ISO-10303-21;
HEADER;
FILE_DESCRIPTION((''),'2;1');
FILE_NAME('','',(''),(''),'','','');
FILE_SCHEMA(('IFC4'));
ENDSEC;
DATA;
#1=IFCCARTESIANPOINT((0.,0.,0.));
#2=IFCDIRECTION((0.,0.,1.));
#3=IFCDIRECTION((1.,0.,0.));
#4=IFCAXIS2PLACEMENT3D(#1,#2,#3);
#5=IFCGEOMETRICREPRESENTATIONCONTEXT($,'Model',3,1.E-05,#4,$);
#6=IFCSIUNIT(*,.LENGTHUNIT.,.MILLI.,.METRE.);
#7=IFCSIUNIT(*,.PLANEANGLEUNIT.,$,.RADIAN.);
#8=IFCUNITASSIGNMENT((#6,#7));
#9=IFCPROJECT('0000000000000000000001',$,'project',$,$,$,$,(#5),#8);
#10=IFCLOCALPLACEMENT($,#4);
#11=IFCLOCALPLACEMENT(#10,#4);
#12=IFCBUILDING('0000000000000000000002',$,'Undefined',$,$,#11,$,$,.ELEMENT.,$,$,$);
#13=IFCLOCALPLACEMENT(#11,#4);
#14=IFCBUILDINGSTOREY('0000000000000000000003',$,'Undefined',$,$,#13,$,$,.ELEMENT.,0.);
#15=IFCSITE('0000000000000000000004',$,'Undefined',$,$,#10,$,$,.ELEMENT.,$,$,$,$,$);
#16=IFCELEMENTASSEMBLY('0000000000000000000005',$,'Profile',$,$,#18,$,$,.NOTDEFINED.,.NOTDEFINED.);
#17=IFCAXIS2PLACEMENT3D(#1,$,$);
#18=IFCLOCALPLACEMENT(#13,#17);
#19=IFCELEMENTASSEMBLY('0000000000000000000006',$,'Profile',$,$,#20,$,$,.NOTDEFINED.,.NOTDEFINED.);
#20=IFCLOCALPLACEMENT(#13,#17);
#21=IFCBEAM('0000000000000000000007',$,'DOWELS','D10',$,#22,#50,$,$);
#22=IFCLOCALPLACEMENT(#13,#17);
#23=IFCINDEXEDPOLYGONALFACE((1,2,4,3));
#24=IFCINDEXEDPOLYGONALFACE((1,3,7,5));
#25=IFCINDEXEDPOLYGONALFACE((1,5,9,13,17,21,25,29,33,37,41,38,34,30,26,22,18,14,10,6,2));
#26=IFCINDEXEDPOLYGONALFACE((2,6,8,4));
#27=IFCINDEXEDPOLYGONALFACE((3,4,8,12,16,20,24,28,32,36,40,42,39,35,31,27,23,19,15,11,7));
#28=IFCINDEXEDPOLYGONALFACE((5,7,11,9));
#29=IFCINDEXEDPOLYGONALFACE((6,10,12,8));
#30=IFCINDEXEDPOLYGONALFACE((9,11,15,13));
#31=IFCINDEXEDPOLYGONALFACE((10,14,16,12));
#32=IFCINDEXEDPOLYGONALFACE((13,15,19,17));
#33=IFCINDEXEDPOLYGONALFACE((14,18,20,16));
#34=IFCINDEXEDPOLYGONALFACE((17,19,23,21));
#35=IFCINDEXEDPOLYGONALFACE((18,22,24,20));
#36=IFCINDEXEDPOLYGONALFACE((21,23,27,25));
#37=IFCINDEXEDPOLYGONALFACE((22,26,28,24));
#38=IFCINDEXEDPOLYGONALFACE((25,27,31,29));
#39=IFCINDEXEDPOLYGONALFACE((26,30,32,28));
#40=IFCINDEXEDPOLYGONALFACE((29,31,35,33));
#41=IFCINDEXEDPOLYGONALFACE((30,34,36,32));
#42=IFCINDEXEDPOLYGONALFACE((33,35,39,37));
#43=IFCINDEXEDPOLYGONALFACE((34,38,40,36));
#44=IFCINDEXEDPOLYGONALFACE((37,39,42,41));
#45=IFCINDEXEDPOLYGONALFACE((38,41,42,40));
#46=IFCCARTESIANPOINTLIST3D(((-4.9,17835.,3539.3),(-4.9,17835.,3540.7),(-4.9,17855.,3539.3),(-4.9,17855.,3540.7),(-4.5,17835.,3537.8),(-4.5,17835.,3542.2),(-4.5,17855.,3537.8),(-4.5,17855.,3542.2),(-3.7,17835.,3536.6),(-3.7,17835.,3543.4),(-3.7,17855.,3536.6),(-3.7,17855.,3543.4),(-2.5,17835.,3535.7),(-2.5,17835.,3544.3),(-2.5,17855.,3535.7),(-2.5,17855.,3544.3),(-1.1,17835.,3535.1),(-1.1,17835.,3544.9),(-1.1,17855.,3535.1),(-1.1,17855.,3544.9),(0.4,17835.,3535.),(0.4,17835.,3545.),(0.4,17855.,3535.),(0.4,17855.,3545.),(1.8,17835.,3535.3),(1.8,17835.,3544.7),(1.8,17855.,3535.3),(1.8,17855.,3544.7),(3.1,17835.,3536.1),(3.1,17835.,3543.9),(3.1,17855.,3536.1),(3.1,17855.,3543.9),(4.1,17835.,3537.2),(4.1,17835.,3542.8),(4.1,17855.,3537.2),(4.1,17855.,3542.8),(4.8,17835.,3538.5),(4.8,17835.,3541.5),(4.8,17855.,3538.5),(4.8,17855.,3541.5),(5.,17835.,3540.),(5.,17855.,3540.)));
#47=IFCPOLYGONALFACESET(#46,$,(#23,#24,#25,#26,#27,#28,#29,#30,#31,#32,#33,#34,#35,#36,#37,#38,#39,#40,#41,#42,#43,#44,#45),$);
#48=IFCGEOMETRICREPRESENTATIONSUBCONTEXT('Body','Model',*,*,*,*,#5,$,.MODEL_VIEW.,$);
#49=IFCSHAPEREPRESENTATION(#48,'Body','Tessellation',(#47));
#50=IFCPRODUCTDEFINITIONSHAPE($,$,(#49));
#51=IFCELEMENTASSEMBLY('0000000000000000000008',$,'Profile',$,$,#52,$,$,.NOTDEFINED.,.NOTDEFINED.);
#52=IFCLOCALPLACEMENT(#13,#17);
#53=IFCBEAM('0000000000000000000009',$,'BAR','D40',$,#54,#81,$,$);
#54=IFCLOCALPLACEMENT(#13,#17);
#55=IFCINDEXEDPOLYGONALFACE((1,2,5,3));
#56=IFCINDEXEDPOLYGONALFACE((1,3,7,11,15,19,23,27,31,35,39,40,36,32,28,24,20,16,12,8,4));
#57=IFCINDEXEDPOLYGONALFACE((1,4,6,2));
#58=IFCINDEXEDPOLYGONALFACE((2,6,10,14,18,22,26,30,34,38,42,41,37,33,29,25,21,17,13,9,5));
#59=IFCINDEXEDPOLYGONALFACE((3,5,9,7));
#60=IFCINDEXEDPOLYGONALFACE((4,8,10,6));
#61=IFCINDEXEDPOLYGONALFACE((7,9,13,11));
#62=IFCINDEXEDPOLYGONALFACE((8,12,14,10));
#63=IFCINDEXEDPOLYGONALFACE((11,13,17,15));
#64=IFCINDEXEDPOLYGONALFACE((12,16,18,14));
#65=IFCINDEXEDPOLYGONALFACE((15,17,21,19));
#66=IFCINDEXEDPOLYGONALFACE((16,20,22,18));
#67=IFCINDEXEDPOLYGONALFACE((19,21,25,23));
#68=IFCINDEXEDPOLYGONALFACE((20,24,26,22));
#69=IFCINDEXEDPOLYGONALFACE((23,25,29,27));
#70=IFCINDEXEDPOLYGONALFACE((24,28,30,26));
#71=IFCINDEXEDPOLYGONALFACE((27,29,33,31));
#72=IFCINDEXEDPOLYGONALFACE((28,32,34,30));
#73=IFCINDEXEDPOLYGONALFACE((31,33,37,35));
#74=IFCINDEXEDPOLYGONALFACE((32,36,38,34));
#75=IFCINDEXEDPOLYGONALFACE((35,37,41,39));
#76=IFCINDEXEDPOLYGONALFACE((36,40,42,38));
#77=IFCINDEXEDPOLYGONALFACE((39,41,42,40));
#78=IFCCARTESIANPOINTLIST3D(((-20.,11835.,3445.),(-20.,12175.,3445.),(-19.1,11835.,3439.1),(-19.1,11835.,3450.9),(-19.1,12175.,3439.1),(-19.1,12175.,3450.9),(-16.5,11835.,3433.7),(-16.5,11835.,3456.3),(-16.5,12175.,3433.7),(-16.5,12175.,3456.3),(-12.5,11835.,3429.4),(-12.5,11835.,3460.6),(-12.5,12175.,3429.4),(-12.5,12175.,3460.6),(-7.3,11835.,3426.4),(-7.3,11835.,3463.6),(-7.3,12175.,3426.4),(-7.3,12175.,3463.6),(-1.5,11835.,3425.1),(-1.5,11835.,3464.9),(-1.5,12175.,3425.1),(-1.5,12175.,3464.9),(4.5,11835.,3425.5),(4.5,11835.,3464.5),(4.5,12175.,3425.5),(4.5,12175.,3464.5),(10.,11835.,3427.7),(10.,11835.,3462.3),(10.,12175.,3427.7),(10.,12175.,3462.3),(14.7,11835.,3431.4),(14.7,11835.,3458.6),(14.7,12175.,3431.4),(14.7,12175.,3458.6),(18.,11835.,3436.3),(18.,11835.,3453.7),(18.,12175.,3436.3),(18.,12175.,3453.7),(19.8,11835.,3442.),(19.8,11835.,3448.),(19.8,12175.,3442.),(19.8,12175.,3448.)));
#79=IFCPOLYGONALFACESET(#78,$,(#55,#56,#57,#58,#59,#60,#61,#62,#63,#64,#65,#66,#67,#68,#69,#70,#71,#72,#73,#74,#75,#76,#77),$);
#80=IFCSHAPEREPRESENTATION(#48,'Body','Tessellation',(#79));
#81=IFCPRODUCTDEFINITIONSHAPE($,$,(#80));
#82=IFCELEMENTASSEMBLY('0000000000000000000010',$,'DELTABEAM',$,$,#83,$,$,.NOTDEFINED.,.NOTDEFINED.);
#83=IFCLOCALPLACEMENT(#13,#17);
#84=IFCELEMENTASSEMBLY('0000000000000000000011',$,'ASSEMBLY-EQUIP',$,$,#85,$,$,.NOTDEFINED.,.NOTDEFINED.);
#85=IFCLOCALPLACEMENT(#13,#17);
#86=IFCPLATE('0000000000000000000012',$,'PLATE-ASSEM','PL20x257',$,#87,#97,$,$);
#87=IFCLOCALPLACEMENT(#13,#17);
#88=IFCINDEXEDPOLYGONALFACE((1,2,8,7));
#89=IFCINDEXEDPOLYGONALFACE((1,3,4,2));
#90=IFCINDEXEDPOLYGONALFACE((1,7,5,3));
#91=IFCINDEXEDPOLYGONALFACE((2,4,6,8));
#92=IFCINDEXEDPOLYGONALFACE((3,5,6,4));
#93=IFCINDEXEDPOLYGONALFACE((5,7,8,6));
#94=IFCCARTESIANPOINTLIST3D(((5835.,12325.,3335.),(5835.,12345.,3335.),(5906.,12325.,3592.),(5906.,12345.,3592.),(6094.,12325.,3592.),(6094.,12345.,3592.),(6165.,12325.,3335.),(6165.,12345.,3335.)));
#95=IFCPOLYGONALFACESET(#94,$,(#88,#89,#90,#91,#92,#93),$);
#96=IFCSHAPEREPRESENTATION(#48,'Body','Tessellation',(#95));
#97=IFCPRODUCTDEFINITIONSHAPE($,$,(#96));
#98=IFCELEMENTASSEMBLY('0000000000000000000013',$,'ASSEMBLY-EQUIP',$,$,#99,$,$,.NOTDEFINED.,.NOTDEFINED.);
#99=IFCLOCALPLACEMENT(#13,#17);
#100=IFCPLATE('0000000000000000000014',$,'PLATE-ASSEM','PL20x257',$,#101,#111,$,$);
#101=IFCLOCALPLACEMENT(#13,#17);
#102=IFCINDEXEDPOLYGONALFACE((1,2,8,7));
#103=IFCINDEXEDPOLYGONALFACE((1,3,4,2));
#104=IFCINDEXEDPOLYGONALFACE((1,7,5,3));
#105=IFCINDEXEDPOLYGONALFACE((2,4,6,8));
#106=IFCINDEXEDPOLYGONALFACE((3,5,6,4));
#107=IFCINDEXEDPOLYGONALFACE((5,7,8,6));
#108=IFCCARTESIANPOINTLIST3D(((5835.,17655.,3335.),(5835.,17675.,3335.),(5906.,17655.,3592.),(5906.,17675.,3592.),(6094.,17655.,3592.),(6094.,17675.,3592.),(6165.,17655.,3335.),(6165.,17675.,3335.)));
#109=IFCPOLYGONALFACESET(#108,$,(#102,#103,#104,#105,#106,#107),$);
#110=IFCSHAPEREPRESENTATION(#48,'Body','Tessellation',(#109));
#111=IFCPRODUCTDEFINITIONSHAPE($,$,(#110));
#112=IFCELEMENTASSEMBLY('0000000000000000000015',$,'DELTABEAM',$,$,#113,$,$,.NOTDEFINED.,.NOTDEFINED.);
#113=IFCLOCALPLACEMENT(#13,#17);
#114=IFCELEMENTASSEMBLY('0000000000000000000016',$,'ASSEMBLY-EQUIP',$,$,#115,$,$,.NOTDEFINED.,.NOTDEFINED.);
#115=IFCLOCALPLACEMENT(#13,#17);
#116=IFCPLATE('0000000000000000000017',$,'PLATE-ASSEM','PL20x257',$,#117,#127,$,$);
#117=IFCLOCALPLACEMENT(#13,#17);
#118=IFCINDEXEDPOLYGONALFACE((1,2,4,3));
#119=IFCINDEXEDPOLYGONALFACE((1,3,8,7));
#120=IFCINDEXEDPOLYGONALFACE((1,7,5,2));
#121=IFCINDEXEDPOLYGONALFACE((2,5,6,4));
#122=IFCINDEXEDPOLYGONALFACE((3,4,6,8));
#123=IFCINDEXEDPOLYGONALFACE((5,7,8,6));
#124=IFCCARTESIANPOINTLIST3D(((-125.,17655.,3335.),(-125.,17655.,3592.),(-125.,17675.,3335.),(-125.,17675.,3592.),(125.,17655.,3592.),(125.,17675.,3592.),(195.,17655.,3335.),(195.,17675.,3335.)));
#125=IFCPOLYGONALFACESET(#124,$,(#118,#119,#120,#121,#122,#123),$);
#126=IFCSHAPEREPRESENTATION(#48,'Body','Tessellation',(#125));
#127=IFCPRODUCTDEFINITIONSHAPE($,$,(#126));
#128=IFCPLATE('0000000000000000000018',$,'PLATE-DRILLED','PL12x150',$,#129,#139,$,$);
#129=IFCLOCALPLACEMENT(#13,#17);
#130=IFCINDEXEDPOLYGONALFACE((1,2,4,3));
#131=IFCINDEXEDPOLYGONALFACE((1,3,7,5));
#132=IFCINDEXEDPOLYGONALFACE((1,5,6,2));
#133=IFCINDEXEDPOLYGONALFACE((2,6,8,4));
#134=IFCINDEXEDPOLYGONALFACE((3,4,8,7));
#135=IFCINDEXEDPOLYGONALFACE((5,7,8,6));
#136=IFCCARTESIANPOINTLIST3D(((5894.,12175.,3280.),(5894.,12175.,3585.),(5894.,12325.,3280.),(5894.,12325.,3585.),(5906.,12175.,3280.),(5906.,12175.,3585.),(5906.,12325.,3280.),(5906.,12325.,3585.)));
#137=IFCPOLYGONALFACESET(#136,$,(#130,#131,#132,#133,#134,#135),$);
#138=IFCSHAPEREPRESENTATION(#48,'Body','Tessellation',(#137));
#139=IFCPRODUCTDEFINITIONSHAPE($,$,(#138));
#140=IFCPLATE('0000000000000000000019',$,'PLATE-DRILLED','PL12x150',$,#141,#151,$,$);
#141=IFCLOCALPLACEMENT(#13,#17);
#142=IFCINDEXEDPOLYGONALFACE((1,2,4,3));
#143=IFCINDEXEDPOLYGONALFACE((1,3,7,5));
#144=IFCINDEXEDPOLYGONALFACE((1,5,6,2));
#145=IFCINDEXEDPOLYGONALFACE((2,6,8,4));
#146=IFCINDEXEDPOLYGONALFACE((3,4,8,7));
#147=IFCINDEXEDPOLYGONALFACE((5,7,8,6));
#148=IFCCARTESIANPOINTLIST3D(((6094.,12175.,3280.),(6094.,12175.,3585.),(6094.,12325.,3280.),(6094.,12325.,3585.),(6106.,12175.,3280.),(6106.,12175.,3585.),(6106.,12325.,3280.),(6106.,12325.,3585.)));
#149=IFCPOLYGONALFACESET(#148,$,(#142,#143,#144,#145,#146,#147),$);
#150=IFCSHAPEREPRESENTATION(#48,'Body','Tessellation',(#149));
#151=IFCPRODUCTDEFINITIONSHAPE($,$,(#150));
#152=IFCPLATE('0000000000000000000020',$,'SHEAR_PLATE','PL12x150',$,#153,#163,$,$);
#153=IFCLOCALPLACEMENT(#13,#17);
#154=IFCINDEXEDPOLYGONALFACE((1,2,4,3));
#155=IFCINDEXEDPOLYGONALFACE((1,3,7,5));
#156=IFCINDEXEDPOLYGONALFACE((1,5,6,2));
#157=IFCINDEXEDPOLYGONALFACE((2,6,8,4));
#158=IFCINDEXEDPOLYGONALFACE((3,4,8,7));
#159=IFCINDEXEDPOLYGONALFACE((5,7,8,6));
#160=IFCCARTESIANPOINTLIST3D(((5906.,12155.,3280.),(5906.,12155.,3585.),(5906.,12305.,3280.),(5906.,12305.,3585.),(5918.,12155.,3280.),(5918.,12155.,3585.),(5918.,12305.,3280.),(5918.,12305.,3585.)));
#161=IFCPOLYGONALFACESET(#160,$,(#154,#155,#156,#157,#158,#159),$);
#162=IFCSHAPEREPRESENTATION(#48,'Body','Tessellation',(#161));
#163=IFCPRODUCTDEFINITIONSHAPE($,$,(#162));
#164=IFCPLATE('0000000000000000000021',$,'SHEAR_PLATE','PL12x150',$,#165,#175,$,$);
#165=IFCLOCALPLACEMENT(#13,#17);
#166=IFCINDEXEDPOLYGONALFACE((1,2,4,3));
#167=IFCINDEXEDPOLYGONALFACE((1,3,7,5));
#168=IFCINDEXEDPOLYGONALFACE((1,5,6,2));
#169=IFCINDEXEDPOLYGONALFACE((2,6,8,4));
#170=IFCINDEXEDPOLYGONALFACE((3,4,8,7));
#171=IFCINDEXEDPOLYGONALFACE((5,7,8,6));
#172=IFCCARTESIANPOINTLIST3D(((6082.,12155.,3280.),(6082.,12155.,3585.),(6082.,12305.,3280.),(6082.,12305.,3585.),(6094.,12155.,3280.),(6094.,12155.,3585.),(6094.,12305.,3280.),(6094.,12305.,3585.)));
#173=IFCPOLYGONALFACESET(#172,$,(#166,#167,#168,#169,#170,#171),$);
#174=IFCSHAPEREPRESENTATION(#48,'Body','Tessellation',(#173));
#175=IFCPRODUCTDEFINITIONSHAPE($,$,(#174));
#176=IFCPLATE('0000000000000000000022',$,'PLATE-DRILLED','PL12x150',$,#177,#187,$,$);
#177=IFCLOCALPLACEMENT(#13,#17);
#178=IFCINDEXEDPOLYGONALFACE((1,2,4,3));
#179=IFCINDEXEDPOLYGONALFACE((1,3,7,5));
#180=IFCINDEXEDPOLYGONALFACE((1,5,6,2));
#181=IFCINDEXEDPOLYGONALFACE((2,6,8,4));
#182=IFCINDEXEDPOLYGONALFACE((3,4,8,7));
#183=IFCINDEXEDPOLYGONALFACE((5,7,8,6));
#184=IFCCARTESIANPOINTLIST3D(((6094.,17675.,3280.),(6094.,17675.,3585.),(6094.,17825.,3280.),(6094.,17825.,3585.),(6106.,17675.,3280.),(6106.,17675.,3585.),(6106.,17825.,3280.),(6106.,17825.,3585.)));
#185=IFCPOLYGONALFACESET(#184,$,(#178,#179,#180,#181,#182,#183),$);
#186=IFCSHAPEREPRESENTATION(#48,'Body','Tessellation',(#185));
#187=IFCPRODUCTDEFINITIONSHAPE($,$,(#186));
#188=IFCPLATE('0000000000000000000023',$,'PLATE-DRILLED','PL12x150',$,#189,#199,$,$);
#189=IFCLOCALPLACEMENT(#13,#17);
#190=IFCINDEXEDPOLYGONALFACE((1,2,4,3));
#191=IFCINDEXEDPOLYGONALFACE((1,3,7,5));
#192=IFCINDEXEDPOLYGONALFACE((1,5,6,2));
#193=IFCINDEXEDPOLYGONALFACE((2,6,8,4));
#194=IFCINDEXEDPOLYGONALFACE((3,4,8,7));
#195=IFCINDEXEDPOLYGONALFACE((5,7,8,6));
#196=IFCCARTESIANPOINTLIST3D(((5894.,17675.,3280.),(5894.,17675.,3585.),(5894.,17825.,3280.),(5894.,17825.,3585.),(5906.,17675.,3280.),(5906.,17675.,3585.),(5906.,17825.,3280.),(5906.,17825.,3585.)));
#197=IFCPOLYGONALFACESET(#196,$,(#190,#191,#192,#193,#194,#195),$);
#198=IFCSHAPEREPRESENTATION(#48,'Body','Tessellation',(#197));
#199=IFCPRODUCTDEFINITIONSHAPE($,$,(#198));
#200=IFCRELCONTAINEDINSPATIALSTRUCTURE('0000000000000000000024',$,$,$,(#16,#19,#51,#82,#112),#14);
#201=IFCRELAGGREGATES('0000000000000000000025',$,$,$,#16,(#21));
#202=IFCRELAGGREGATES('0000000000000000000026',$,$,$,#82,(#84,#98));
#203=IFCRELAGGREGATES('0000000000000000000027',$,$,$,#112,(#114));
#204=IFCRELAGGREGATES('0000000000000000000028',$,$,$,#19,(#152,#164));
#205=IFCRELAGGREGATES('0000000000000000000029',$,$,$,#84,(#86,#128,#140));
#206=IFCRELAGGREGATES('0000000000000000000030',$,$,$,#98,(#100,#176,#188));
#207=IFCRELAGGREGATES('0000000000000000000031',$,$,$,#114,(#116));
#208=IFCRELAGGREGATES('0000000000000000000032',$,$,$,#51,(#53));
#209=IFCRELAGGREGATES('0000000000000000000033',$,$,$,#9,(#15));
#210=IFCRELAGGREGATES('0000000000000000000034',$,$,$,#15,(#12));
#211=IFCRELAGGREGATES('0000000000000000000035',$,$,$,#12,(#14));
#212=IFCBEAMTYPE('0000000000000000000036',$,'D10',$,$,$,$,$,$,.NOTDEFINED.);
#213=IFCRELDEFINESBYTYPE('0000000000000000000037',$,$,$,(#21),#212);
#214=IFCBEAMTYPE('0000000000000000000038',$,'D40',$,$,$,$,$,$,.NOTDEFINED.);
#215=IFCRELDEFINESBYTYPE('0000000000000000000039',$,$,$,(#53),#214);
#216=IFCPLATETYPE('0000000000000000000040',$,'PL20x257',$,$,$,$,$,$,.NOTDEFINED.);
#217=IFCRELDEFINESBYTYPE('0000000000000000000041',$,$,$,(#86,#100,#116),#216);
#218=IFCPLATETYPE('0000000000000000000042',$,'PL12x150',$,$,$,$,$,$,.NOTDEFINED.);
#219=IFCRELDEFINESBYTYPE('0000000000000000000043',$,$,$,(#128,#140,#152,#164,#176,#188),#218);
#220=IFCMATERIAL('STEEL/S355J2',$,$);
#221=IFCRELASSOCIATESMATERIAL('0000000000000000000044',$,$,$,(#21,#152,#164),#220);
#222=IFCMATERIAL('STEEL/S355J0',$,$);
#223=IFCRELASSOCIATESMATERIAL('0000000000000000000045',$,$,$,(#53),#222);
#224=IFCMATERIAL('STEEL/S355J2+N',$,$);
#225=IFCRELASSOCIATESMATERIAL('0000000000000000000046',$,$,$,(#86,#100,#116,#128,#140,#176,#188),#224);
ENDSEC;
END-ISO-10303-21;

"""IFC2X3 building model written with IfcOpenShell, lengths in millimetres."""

from ifc_helpers import new_model, si_unit, frame, origin_with_axes, origin_2d_with_axis, place, context, subcontext, project, spatial, polyline, circle, outline, extrude, material, type_object, element, aggregate, save


model = new_model("IFC2X3")

# Units and contexts
model_context = context("Model", 3, precision=1e-05, world=origin_with_axes())
body_context = subcontext(model_context, "Body", "Model", "MODEL_VIEW")
ifc_project = project(units=[si_unit("LENGTHUNIT", "METRE", prefix="MILLI"), si_unit("PLANEANGLEUNIT", "RADIAN")], contexts=[model_context])

# Site, building, storey
site_placement = place(None, origin_with_axes())
site = spatial("IfcSite", under=ifc_project, at=site_placement, Name="Undefined", CompositionType="ELEMENT")
building_placement = place(site_placement, origin_with_axes())
building = spatial("IfcBuilding", under=site, at=building_placement, Name="Undefined", CompositionType="ELEMENT")
storey_placement = place(building_placement, origin_with_axes())
storey = spatial("IfcBuildingStorey", under=building, at=storey_placement, Name="Undefined", CompositionType="ELEMENT", Elevation=0.0)

# Element assembly
assembly_1_placement = place(storey_placement, origin_with_axes())
assembly_1 = element("IfcElementAssembly", 1, at=assembly_1_placement, inside=storey, Name="Profile", AssemblyPlace="NOTDEFINED", PredefinedType="NOTDEFINED")

# Element assembly
assembly_2_placement = place(storey_placement, origin_with_axes())
assembly_2 = element("IfcElementAssembly", 2, at=assembly_2_placement, inside=storey, Name="Profile", AssemblyPlace="NOTDEFINED", PredefinedType="NOTDEFINED")
ifc_material_1 = material(Name="STEEL/S355J2")
beam_type_1 = type_object("IfcBeamType", Name="D10", PredefinedType="NOTDEFINED")

# Beam
beam_1_placement = place(assembly_1_placement, frame((0.0, 17835.0, 3540.0), z_axis=(0.0, 0.0, 1.0), x_axis=(0.0, 1.0, 0.0)))
beam_1 = element("IfcBeam", 3, at=beam_1_placement, type_object=beam_type_1, material=ifc_material_1, Name="DOWELS", Description="D10", context=body_context, shape_type="SweptSolid", body=[
    extrude(circle(Radius=5.0, at=origin_2d_with_axis()), frame((20.0, 0.0, 0.0), z_axis=(-1.0, 0.0, 0.0), x_axis=(0.0, -1.0, 0.0)), (0.0, 0.0, 1.0), 20.0),
])
aggregate(assembly_1, [beam_1])

# Element assembly, beam
assembly_3_placement = place(storey_placement, origin_with_axes())
assembly_3 = element("IfcElementAssembly", 4, at=assembly_3_placement, inside=storey, Name="Profile", AssemblyPlace="NOTDEFINED", PredefinedType="NOTDEFINED")
ifc_material_2 = material(Name="STEEL/S355J0")
beam_type_2 = type_object("IfcBeamType", Name="D40", PredefinedType="NOTDEFINED")
beam_2_placement = place(assembly_3_placement, frame((0.0, 12175.0, 3445.0), z_axis=(0.0, 0.0, 1.0), x_axis=(0.0, -1.0, 0.0)))
beam_2 = element("IfcBeam", 5, at=beam_2_placement, type_object=beam_type_2, material=ifc_material_2, Name="BAR", Description="D40", context=body_context, shape_type="SweptSolid", body=[
    extrude(circle(Radius=20.0, at=origin_2d_with_axis()), frame((340.0, 0.0, 0.0), z_axis=(-1.0, 0.0, 0.0), x_axis=(0.0, -1.0, 0.0)), (0.0, 0.0, 1.0), 340.0),
])

# Element assemblies, plates
assembly_4_placement = place(storey_placement, origin_with_axes())
assembly_4 = element("IfcElementAssembly", 6, at=assembly_4_placement, inside=storey, Name="DELTABEAM", AssemblyPlace="NOTDEFINED", PredefinedType="NOTDEFINED")
assembly_5_placement = place(assembly_4_placement, origin_with_axes())
assembly_5 = element("IfcElementAssembly", 7, at=assembly_5_placement, Name="ASSEMBLY-EQUIP", AssemblyPlace="NOTDEFINED", PredefinedType="NOTDEFINED")
ifc_material_3 = material(Name="STEEL/S355J2+N")
plate_type_1 = type_object("IfcPlateType", Name="PL20x257", PredefinedType="NOTDEFINED")
plate_1_placement = place(assembly_5_placement, frame((6165.0, 12335.0, 3335.0), z_axis=(0.0, 1.0, 0.0), x_axis=(-1.0, 0.0, 0.0)))
plate_1 = element("IfcPlate", 8, at=plate_1_placement, type_object=plate_type_1, material=ifc_material_3, Name="PLATE-ASSEM", Description="PL20x257", context=body_context, shape_type="SweptSolid", body=[
    extrude(outline(polyline([(0.0, 0.0), (330.0, 0.0), (259.0, 257.0), (71.0, 257.0), (0.0, 0.0)])), frame((0.0, 0.0, -10.0), z_axis=(0.0, 0.0, 1.0), x_axis=(1.0, 0.0, 0.0)), (0.0, 0.0, 1.0), 20.0),
])
assembly_6_placement = place(assembly_4_placement, origin_with_axes())
assembly_6 = element("IfcElementAssembly", 9, at=assembly_6_placement, Name="ASSEMBLY-EQUIP", AssemblyPlace="NOTDEFINED", PredefinedType="NOTDEFINED")
aggregate(assembly_4, [assembly_5, assembly_6])
plate_2_placement = place(assembly_6_placement, frame((5835.0, 17665.0, 3335.0), z_axis=(0.0, -1.0, 0.0), x_axis=(1.0, 0.0, 0.0)))
plate_2 = element("IfcPlate", 10, at=plate_2_placement, type_object=plate_type_1, material=ifc_material_3, Name="PLATE-ASSEM", Description="PL20x257", context=body_context, shape_type="SweptSolid", body=[
    extrude(outline(polyline([(0.0, 0.0), (330.0, 0.0), (259.0, 257.0), (71.0, 257.0), (0.0, 0.0)])), frame((0.0, 0.0, -10.0), z_axis=(0.0, 0.0, 1.0), x_axis=(1.0, 0.0, 0.0)), (0.0, 0.0, 1.0), 20.0),
])
assembly_7_placement = place(storey_placement, origin_with_axes())
assembly_7 = element("IfcElementAssembly", 11, at=assembly_7_placement, inside=storey, Name="DELTABEAM", AssemblyPlace="NOTDEFINED", PredefinedType="NOTDEFINED")
assembly_8_placement = place(assembly_7_placement, origin_with_axes())
assembly_8 = element("IfcElementAssembly", 12, at=assembly_8_placement, Name="ASSEMBLY-EQUIP", AssemblyPlace="NOTDEFINED", PredefinedType="NOTDEFINED")
plate_3_placement = place(assembly_8_placement, frame((-125.0, 17665.0, 3335.0), z_axis=(0.0, -1.0, 0.0), x_axis=(1.0, 0.0, 0.0)))
plate_3 = element("IfcPlate", 13, at=plate_3_placement, type_object=plate_type_1, material=ifc_material_3, Name="PLATE-ASSEM", Description="PL20x257", context=body_context, shape_type="SweptSolid", body=[
    extrude(outline(polyline([(0.0, 0.0), (320.0, 0.0), (250.0, 257.0), (0.0, 257.0), (0.0, 0.0)])), frame((0.0, 0.0, -10.0), z_axis=(0.0, 0.0, 1.0), x_axis=(1.0, 0.0, 0.0)), (0.0, 0.0, 1.0), 20.0),
])
aggregate(assembly_7, [assembly_8])

# Plates
plate_type_2 = type_object("IfcPlateType", Name="PL12x150", PredefinedType="NOTDEFINED")
plate_4_placement = place(assembly_5_placement, frame((5900.0, 12325.0, 3585.0), z_axis=(1.0, 0.0, 0.0), x_axis=(0.0, -1.0, 0.0)))
plate_4 = element("IfcPlate", 14, at=plate_4_placement, type_object=plate_type_2, material=ifc_material_3, Name="PLATE-DRILLED", Description="PL12x150", context=body_context, shape_type="SweptSolid", body=[
    extrude(outline(polyline([(0.0, 0.0), (150.0, 0.0), (150.0, 0.0), (150.0, 305.0), (150.0, 305.0), (0.0, 305.0), (0.0, 305.0), (0.0, 0.0)])), frame((0.0, 0.0, -6.0), z_axis=(0.0, 0.0, 1.0), x_axis=(1.0, 0.0, 0.0)), (0.0, 0.0, 1.0), 12.0),
])
plate_5_placement = place(assembly_5_placement, frame((6100.0, 12325.0, 3585.0), z_axis=(1.0, 0.0, 0.0), x_axis=(0.0, -1.0, 0.0)))
plate_5 = element("IfcPlate", 15, at=plate_5_placement, type_object=plate_type_2, material=ifc_material_3, Name="PLATE-DRILLED", Description="PL12x150", context=body_context, shape_type="SweptSolid", body=[
    extrude(outline(polyline([(0.0, 0.0), (150.0, 0.0), (150.0, 0.0), (150.0, 305.0), (150.0, 305.0), (0.0, 305.0), (0.0, 305.0), (0.0, 0.0)])), frame((0.0, 0.0, -6.0), z_axis=(0.0, 0.0, 1.0), x_axis=(1.0, 0.0, 0.0)), (0.0, 0.0, 1.0), 12.0),
])
plate_6_placement = place(assembly_2_placement, frame((5912.0, 12155.0, 3585.0), z_axis=(-1.0, 0.0, 0.0), x_axis=(0.0, 1.0, 0.0)))
plate_6 = element("IfcPlate", 16, at=plate_6_placement, type_object=plate_type_2, material=ifc_material_1, Name="SHEAR_PLATE", Description="PL12x150", context=body_context, shape_type="SweptSolid", body=[
    extrude(outline(polyline([(0.0, 0.0), (150.0, 0.0), (150.0, 0.0), (150.0, 305.0), (150.0, 305.0), (0.0, 305.0), (0.0, 305.0), (0.0, 0.0)])), frame((0.0, 0.0, -6.0), z_axis=(0.0, 0.0, 1.0), x_axis=(1.0, 0.0, 0.0)), (0.0, 0.0, 1.0), 12.0),
])
plate_7_placement = place(assembly_2_placement, frame((6088.0, 12155.0, 3585.0), z_axis=(-1.0, 0.0, 0.0), x_axis=(0.0, 1.0, 0.0)))
plate_7 = element("IfcPlate", 17, at=plate_7_placement, type_object=plate_type_2, material=ifc_material_1, Name="SHEAR_PLATE", Description="PL12x150", context=body_context, shape_type="SweptSolid", body=[
    extrude(outline(polyline([(0.0, 0.0), (150.0, 0.0), (150.0, 0.0), (150.0, 305.0), (150.0, 305.0), (0.0, 305.0), (0.0, 305.0), (0.0, 0.0)])), frame((0.0, 0.0, -6.0), z_axis=(0.0, 0.0, 1.0), x_axis=(1.0, 0.0, 0.0)), (0.0, 0.0, 1.0), 12.0),
])
aggregate(assembly_2, [plate_6, plate_7])
plate_8_placement = place(assembly_6_placement, frame((6100.0, 17675.0, 3585.0), z_axis=(-1.0, 0.0, 0.0), x_axis=(0.0, 1.0, 0.0)))
plate_8 = element("IfcPlate", 18, at=plate_8_placement, type_object=plate_type_2, material=ifc_material_3, Name="PLATE-DRILLED", Description="PL12x150", context=body_context, shape_type="SweptSolid", body=[
    extrude(outline(polyline([(0.0, 0.0), (150.0, 0.0), (150.0, 0.0), (150.0, 305.0), (150.0, 305.0), (0.0, 305.0), (0.0, 305.0), (0.0, 0.0)])), frame((0.0, 0.0, -6.0), z_axis=(0.0, 0.0, 1.0), x_axis=(1.0, 0.0, 0.0)), (0.0, 0.0, 1.0), 12.0),
])
plate_9_placement = place(assembly_6_placement, frame((5900.0, 17675.0, 3585.0), z_axis=(-1.0, 0.0, 0.0), x_axis=(0.0, 1.0, 0.0)))
plate_9 = element("IfcPlate", 19, at=plate_9_placement, type_object=plate_type_2, material=ifc_material_3, Name="PLATE-DRILLED", Description="PL12x150", context=body_context, shape_type="SweptSolid", body=[
    extrude(outline(polyline([(0.0, 0.0), (150.0, 0.0), (150.0, 0.0), (150.0, 305.0), (150.0, 305.0), (0.0, 305.0), (0.0, 305.0), (0.0, 0.0)])), frame((0.0, 0.0, -6.0), z_axis=(0.0, 0.0, 1.0), x_axis=(1.0, 0.0, 0.0)), (0.0, 0.0, 1.0), 12.0),
])

aggregate(assembly_5, [plate_1, plate_4, plate_5])
aggregate(assembly_6, [plate_2, plate_8, plate_9])
aggregate(assembly_8, [plate_3])
aggregate(assembly_3, [beam_2])

save(model, "model.ifc")
